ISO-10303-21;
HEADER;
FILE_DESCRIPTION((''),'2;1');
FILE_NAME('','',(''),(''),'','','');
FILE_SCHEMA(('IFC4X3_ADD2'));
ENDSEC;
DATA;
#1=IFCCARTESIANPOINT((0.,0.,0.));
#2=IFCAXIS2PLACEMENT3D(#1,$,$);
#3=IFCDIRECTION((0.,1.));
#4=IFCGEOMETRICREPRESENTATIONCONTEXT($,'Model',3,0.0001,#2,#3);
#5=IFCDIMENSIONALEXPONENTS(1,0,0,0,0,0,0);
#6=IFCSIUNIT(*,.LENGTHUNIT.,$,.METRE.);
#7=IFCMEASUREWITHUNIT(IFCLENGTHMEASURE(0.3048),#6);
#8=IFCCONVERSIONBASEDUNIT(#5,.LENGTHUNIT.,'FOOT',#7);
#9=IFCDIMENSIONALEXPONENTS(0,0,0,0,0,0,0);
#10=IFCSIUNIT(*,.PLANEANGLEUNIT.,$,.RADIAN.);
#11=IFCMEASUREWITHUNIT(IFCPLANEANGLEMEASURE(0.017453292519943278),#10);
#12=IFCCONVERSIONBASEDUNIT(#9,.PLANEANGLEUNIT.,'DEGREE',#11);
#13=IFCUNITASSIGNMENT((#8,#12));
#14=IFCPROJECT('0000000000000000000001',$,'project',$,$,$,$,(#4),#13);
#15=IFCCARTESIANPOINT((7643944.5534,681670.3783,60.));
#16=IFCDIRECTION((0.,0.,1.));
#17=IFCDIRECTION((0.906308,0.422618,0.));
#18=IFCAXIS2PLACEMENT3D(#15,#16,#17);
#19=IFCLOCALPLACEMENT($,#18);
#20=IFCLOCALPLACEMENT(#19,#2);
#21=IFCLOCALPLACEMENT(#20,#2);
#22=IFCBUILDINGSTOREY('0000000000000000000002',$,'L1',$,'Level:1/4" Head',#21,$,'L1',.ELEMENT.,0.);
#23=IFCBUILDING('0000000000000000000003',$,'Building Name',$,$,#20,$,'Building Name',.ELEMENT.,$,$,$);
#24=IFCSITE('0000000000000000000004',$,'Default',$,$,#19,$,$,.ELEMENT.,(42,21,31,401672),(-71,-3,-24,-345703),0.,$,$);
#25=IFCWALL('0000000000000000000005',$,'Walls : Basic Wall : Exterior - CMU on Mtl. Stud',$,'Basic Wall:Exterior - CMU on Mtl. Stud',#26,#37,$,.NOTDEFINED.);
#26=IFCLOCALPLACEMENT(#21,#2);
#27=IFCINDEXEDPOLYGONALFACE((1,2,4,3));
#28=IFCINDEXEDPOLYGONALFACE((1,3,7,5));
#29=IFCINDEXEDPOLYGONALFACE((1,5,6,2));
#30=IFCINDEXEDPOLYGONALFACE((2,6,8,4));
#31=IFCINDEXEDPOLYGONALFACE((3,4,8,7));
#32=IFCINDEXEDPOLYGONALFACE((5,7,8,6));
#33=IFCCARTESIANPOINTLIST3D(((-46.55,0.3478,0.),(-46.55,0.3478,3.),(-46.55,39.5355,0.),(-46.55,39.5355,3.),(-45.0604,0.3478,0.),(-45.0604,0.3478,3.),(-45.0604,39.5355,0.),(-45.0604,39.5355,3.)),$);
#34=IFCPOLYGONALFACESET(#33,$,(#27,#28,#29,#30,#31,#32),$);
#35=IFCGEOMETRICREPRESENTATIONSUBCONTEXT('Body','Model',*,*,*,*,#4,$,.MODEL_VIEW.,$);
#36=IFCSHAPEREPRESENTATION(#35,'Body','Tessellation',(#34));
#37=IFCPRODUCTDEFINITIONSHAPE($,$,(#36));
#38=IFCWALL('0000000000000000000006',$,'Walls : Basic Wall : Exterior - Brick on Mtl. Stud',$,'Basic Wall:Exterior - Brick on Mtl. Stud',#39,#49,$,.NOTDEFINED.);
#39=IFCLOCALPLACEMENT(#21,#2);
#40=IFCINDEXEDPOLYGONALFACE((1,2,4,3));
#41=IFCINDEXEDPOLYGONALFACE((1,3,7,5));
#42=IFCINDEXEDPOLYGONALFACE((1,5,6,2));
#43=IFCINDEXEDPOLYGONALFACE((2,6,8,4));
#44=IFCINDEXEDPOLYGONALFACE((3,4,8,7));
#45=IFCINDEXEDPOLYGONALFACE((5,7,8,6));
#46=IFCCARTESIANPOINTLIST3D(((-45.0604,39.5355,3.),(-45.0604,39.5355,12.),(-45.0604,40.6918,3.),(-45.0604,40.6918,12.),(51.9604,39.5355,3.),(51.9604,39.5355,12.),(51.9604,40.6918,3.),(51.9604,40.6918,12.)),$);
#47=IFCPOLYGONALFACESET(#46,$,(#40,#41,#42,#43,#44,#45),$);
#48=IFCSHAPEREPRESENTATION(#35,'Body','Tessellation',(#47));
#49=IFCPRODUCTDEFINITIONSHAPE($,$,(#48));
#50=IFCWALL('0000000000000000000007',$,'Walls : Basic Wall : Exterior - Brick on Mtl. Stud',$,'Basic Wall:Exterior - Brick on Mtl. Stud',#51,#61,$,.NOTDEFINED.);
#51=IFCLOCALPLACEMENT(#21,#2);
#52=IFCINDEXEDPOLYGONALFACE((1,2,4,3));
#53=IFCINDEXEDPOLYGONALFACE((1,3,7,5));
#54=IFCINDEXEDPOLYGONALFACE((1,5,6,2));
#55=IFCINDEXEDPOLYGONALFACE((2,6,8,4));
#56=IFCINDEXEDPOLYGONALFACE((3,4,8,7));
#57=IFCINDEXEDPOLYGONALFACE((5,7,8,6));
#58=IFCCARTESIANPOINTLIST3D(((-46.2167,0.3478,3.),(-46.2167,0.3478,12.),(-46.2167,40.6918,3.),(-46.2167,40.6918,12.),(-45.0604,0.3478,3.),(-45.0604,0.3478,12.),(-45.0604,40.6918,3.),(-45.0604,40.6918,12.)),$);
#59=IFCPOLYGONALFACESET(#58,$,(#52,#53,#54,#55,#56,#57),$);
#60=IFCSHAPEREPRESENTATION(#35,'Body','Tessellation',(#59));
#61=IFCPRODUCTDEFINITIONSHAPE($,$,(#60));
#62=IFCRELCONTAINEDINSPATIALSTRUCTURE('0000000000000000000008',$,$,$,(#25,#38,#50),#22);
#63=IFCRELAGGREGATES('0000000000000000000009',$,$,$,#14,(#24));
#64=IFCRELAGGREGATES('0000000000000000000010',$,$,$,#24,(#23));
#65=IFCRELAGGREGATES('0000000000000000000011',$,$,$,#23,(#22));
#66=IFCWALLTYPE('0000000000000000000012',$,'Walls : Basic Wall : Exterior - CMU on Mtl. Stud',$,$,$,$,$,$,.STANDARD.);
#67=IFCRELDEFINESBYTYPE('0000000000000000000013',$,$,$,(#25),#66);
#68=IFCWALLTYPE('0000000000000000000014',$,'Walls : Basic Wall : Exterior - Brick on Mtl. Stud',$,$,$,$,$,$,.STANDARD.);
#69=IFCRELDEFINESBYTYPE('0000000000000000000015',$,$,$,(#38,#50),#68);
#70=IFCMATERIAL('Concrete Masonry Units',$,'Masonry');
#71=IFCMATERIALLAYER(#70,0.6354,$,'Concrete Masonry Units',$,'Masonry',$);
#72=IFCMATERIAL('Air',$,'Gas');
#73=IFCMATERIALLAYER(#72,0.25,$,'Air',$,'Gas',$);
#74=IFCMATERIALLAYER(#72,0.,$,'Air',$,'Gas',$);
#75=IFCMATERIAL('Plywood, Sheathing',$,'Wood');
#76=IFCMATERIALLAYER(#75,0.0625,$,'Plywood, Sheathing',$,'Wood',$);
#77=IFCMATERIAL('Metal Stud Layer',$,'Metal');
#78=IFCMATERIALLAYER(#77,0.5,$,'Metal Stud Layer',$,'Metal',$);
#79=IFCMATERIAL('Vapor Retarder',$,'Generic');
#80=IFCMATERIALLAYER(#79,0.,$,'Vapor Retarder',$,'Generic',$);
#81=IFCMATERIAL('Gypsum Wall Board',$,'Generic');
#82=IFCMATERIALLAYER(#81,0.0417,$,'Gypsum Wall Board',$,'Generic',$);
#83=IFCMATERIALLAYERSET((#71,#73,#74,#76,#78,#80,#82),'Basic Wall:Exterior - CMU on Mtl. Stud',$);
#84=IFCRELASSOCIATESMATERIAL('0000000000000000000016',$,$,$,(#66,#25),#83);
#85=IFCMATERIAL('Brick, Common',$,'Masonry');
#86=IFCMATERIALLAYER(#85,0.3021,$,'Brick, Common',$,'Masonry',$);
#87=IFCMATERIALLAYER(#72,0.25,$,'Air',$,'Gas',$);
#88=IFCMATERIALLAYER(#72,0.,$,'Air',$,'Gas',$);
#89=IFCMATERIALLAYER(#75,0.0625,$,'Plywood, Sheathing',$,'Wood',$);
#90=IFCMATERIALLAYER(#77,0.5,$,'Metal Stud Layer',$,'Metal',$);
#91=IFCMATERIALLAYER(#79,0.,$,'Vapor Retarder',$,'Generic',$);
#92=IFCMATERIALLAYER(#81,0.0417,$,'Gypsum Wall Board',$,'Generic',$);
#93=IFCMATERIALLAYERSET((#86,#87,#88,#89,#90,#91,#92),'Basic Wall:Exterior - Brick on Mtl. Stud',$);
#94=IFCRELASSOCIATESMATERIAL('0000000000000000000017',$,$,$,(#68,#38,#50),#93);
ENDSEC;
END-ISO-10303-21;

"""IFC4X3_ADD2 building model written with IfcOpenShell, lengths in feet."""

from ifc_helpers import new_model, entity, si_unit, converted_unit, direction, frame, frame_2d, origin, place, context, subcontext, project, spatial, rectangle, extrude, material, layer, layer_set, type_object, element, save


model = new_model("IFC4X3_ADD2")

# Units and contexts
model_context = context("Model", 3, precision=0.0001, world=origin(), true_north=direction((0.0, 1.0)))
body_context = subcontext(model_context, "Body", "Model", "MODEL_VIEW")
ifc_project = project(units=[converted_unit("LENGTHUNIT", "FOOT", entity("IfcLengthMeasure", 0.3048), si_unit("LENGTHUNIT", "METRE"), dimensions=[1, 0, 0, 0, 0, 0, 0]), converted_unit("PLANEANGLEUNIT", "DEGREE", entity("IfcPlaneAngleMeasure", 0.017453292519943278), si_unit("PLANEANGLEUNIT", "RADIAN"), dimensions=[0, 0, 0, 0, 0, 0, 0])], contexts=[model_context])

# Site, building, storey
site_placement = place(None, frame((7643944.5534, 681670.3783, 60.0), z_axis=(0.0, 0.0, 1.0), x_axis=(0.906308, 0.422618, 0.0)))
site = spatial("IfcSite", under=ifc_project, at=site_placement, Name="Default", CompositionType="ELEMENT", RefLatitude=(42, 21, 31, 401672), RefLongitude=(-71, -3, -24, -345703), RefElevation=0.0)
building_placement = place(site_placement, origin())
building = spatial("IfcBuilding", under=site, at=building_placement, Name="Building Name", LongName="Building Name", CompositionType="ELEMENT")
storey_placement = place(building_placement, origin())
storey = spatial("IfcBuildingStorey", under=building, at=storey_placement, Name="L1", ObjectType="Level:1/4\" Head", LongName="L1", CompositionType="ELEMENT", Elevation=0.0)

# Walls
ifc_material_1 = material(Name="Concrete Masonry Units", Category="Masonry")
ifc_layer_1 = layer(ifc_material_1, 0.6354, Name="Concrete Masonry Units", Category="Masonry")
ifc_material_2 = material(Name="Air", Category="Gas")
ifc_layer_2 = layer(ifc_material_2, 0.25, Name="Air", Category="Gas")
ifc_layer_3 = layer(ifc_material_2, 0.0, Name="Air", Category="Gas")
ifc_material_3 = material(Name="Plywood, Sheathing", Category="Wood")
ifc_layer_4 = layer(ifc_material_3, 0.0625, Name="Plywood, Sheathing", Category="Wood")
ifc_material_4 = material(Name="Metal Stud Layer", Category="Metal")
ifc_layer_5 = layer(ifc_material_4, 0.5, Name="Metal Stud Layer", Category="Metal")
ifc_material_5 = material(Name="Vapor Retarder", Category="Generic")
ifc_layer_6 = layer(ifc_material_5, 0.0, Name="Vapor Retarder", Category="Generic")
ifc_material_6 = material(Name="Gypsum Wall Board", Category="Generic")
ifc_layer_7 = layer(ifc_material_6, 0.0417, Name="Gypsum Wall Board", Category="Generic")
ifc_layer_set_1 = layer_set([ifc_layer_1, ifc_layer_2, ifc_layer_3, ifc_layer_4, ifc_layer_5, ifc_layer_6, ifc_layer_7], Name="Basic Wall:Exterior - CMU on Mtl. Stud")
wall_type_1 = type_object("IfcWallType", Name="Walls : Basic Wall : Exterior - CMU on Mtl. Stud", PredefinedType="STANDARD", material=ifc_layer_set_1)
wall_1_placement = place(storey_placement, frame((-45.8052, 0.3478, 0.0), z_axis=(0.0, 0.0, 1.0), x_axis=(0.0, 1.0, 0.0)))
element("IfcWall", 1, at=wall_1_placement, inside=storey, type_object=wall_type_1, material=ifc_layer_set_1, Name="Walls : Basic Wall : Exterior - CMU on Mtl. Stud", ObjectType="Basic Wall:Exterior - CMU on Mtl. Stud", PredefinedType="NOTDEFINED", context=body_context, shape_type="SweptSolid", body=[
    extrude(rectangle(XDim=39.1877, YDim=1.4896, at=frame_2d((19.5939, 0.0), x_axis=(-1.0, 0.0))), origin(), (0.0, 0.0, 1.0), 3.0),
])
ifc_material_7 = material(Name="Brick, Common", Category="Masonry")
ifc_layer_8 = layer(ifc_material_7, 0.3021, Name="Brick, Common", Category="Masonry")
ifc_layer_9 = layer(ifc_material_2, 0.25, Name="Air", Category="Gas")
ifc_layer_10 = layer(ifc_material_2, 0.0, Name="Air", Category="Gas")
ifc_layer_11 = layer(ifc_material_3, 0.0625, Name="Plywood, Sheathing", Category="Wood")
ifc_layer_12 = layer(ifc_material_4, 0.5, Name="Metal Stud Layer", Category="Metal")
ifc_layer_13 = layer(ifc_material_5, 0.0, Name="Vapor Retarder", Category="Generic")
ifc_layer_14 = layer(ifc_material_6, 0.0417, Name="Gypsum Wall Board", Category="Generic")
ifc_layer_set_2 = layer_set([ifc_layer_8, ifc_layer_9, ifc_layer_10, ifc_layer_11, ifc_layer_12, ifc_layer_13, ifc_layer_14], Name="Basic Wall:Exterior - Brick on Mtl. Stud")
wall_type_2 = type_object("IfcWallType", Name="Walls : Basic Wall : Exterior - Brick on Mtl. Stud", PredefinedType="STANDARD", material=ifc_layer_set_2)
wall_2_placement = place(storey_placement, frame((-45.0604, 40.1136, 3.0)))
element("IfcWall", 2, at=wall_2_placement, inside=storey, type_object=wall_type_2, material=ifc_layer_set_2, Name="Walls : Basic Wall : Exterior - Brick on Mtl. Stud", ObjectType="Basic Wall:Exterior - Brick on Mtl. Stud", PredefinedType="NOTDEFINED", context=body_context, shape_type="SweptSolid", body=[
    extrude(rectangle(XDim=97.0208, YDim=1.1563, at=frame_2d((48.5104, 0.0), x_axis=(-1.0, 0.0))), origin(), (0.0, 0.0, 1.0), 9.0),
])
wall_3_placement = place(storey_placement, frame((-45.6385, 0.3478, 3.0), z_axis=(0.0, 0.0, 1.0), x_axis=(0.0, 1.0, 0.0)))
element("IfcWall", 3, at=wall_3_placement, inside=storey, type_object=wall_type_2, material=ifc_layer_set_2, Name="Walls : Basic Wall : Exterior - Brick on Mtl. Stud", ObjectType="Basic Wall:Exterior - Brick on Mtl. Stud", PredefinedType="NOTDEFINED", context=body_context, shape_type="SweptSolid", body=[
    extrude(rectangle(XDim=40.344, YDim=1.1562, at=frame_2d((20.172, 0.0), x_axis=(-1.0, 0.0))), origin(), (0.0, 0.0, 1.0), 9.0),
])

save(model, "model.ifc")
